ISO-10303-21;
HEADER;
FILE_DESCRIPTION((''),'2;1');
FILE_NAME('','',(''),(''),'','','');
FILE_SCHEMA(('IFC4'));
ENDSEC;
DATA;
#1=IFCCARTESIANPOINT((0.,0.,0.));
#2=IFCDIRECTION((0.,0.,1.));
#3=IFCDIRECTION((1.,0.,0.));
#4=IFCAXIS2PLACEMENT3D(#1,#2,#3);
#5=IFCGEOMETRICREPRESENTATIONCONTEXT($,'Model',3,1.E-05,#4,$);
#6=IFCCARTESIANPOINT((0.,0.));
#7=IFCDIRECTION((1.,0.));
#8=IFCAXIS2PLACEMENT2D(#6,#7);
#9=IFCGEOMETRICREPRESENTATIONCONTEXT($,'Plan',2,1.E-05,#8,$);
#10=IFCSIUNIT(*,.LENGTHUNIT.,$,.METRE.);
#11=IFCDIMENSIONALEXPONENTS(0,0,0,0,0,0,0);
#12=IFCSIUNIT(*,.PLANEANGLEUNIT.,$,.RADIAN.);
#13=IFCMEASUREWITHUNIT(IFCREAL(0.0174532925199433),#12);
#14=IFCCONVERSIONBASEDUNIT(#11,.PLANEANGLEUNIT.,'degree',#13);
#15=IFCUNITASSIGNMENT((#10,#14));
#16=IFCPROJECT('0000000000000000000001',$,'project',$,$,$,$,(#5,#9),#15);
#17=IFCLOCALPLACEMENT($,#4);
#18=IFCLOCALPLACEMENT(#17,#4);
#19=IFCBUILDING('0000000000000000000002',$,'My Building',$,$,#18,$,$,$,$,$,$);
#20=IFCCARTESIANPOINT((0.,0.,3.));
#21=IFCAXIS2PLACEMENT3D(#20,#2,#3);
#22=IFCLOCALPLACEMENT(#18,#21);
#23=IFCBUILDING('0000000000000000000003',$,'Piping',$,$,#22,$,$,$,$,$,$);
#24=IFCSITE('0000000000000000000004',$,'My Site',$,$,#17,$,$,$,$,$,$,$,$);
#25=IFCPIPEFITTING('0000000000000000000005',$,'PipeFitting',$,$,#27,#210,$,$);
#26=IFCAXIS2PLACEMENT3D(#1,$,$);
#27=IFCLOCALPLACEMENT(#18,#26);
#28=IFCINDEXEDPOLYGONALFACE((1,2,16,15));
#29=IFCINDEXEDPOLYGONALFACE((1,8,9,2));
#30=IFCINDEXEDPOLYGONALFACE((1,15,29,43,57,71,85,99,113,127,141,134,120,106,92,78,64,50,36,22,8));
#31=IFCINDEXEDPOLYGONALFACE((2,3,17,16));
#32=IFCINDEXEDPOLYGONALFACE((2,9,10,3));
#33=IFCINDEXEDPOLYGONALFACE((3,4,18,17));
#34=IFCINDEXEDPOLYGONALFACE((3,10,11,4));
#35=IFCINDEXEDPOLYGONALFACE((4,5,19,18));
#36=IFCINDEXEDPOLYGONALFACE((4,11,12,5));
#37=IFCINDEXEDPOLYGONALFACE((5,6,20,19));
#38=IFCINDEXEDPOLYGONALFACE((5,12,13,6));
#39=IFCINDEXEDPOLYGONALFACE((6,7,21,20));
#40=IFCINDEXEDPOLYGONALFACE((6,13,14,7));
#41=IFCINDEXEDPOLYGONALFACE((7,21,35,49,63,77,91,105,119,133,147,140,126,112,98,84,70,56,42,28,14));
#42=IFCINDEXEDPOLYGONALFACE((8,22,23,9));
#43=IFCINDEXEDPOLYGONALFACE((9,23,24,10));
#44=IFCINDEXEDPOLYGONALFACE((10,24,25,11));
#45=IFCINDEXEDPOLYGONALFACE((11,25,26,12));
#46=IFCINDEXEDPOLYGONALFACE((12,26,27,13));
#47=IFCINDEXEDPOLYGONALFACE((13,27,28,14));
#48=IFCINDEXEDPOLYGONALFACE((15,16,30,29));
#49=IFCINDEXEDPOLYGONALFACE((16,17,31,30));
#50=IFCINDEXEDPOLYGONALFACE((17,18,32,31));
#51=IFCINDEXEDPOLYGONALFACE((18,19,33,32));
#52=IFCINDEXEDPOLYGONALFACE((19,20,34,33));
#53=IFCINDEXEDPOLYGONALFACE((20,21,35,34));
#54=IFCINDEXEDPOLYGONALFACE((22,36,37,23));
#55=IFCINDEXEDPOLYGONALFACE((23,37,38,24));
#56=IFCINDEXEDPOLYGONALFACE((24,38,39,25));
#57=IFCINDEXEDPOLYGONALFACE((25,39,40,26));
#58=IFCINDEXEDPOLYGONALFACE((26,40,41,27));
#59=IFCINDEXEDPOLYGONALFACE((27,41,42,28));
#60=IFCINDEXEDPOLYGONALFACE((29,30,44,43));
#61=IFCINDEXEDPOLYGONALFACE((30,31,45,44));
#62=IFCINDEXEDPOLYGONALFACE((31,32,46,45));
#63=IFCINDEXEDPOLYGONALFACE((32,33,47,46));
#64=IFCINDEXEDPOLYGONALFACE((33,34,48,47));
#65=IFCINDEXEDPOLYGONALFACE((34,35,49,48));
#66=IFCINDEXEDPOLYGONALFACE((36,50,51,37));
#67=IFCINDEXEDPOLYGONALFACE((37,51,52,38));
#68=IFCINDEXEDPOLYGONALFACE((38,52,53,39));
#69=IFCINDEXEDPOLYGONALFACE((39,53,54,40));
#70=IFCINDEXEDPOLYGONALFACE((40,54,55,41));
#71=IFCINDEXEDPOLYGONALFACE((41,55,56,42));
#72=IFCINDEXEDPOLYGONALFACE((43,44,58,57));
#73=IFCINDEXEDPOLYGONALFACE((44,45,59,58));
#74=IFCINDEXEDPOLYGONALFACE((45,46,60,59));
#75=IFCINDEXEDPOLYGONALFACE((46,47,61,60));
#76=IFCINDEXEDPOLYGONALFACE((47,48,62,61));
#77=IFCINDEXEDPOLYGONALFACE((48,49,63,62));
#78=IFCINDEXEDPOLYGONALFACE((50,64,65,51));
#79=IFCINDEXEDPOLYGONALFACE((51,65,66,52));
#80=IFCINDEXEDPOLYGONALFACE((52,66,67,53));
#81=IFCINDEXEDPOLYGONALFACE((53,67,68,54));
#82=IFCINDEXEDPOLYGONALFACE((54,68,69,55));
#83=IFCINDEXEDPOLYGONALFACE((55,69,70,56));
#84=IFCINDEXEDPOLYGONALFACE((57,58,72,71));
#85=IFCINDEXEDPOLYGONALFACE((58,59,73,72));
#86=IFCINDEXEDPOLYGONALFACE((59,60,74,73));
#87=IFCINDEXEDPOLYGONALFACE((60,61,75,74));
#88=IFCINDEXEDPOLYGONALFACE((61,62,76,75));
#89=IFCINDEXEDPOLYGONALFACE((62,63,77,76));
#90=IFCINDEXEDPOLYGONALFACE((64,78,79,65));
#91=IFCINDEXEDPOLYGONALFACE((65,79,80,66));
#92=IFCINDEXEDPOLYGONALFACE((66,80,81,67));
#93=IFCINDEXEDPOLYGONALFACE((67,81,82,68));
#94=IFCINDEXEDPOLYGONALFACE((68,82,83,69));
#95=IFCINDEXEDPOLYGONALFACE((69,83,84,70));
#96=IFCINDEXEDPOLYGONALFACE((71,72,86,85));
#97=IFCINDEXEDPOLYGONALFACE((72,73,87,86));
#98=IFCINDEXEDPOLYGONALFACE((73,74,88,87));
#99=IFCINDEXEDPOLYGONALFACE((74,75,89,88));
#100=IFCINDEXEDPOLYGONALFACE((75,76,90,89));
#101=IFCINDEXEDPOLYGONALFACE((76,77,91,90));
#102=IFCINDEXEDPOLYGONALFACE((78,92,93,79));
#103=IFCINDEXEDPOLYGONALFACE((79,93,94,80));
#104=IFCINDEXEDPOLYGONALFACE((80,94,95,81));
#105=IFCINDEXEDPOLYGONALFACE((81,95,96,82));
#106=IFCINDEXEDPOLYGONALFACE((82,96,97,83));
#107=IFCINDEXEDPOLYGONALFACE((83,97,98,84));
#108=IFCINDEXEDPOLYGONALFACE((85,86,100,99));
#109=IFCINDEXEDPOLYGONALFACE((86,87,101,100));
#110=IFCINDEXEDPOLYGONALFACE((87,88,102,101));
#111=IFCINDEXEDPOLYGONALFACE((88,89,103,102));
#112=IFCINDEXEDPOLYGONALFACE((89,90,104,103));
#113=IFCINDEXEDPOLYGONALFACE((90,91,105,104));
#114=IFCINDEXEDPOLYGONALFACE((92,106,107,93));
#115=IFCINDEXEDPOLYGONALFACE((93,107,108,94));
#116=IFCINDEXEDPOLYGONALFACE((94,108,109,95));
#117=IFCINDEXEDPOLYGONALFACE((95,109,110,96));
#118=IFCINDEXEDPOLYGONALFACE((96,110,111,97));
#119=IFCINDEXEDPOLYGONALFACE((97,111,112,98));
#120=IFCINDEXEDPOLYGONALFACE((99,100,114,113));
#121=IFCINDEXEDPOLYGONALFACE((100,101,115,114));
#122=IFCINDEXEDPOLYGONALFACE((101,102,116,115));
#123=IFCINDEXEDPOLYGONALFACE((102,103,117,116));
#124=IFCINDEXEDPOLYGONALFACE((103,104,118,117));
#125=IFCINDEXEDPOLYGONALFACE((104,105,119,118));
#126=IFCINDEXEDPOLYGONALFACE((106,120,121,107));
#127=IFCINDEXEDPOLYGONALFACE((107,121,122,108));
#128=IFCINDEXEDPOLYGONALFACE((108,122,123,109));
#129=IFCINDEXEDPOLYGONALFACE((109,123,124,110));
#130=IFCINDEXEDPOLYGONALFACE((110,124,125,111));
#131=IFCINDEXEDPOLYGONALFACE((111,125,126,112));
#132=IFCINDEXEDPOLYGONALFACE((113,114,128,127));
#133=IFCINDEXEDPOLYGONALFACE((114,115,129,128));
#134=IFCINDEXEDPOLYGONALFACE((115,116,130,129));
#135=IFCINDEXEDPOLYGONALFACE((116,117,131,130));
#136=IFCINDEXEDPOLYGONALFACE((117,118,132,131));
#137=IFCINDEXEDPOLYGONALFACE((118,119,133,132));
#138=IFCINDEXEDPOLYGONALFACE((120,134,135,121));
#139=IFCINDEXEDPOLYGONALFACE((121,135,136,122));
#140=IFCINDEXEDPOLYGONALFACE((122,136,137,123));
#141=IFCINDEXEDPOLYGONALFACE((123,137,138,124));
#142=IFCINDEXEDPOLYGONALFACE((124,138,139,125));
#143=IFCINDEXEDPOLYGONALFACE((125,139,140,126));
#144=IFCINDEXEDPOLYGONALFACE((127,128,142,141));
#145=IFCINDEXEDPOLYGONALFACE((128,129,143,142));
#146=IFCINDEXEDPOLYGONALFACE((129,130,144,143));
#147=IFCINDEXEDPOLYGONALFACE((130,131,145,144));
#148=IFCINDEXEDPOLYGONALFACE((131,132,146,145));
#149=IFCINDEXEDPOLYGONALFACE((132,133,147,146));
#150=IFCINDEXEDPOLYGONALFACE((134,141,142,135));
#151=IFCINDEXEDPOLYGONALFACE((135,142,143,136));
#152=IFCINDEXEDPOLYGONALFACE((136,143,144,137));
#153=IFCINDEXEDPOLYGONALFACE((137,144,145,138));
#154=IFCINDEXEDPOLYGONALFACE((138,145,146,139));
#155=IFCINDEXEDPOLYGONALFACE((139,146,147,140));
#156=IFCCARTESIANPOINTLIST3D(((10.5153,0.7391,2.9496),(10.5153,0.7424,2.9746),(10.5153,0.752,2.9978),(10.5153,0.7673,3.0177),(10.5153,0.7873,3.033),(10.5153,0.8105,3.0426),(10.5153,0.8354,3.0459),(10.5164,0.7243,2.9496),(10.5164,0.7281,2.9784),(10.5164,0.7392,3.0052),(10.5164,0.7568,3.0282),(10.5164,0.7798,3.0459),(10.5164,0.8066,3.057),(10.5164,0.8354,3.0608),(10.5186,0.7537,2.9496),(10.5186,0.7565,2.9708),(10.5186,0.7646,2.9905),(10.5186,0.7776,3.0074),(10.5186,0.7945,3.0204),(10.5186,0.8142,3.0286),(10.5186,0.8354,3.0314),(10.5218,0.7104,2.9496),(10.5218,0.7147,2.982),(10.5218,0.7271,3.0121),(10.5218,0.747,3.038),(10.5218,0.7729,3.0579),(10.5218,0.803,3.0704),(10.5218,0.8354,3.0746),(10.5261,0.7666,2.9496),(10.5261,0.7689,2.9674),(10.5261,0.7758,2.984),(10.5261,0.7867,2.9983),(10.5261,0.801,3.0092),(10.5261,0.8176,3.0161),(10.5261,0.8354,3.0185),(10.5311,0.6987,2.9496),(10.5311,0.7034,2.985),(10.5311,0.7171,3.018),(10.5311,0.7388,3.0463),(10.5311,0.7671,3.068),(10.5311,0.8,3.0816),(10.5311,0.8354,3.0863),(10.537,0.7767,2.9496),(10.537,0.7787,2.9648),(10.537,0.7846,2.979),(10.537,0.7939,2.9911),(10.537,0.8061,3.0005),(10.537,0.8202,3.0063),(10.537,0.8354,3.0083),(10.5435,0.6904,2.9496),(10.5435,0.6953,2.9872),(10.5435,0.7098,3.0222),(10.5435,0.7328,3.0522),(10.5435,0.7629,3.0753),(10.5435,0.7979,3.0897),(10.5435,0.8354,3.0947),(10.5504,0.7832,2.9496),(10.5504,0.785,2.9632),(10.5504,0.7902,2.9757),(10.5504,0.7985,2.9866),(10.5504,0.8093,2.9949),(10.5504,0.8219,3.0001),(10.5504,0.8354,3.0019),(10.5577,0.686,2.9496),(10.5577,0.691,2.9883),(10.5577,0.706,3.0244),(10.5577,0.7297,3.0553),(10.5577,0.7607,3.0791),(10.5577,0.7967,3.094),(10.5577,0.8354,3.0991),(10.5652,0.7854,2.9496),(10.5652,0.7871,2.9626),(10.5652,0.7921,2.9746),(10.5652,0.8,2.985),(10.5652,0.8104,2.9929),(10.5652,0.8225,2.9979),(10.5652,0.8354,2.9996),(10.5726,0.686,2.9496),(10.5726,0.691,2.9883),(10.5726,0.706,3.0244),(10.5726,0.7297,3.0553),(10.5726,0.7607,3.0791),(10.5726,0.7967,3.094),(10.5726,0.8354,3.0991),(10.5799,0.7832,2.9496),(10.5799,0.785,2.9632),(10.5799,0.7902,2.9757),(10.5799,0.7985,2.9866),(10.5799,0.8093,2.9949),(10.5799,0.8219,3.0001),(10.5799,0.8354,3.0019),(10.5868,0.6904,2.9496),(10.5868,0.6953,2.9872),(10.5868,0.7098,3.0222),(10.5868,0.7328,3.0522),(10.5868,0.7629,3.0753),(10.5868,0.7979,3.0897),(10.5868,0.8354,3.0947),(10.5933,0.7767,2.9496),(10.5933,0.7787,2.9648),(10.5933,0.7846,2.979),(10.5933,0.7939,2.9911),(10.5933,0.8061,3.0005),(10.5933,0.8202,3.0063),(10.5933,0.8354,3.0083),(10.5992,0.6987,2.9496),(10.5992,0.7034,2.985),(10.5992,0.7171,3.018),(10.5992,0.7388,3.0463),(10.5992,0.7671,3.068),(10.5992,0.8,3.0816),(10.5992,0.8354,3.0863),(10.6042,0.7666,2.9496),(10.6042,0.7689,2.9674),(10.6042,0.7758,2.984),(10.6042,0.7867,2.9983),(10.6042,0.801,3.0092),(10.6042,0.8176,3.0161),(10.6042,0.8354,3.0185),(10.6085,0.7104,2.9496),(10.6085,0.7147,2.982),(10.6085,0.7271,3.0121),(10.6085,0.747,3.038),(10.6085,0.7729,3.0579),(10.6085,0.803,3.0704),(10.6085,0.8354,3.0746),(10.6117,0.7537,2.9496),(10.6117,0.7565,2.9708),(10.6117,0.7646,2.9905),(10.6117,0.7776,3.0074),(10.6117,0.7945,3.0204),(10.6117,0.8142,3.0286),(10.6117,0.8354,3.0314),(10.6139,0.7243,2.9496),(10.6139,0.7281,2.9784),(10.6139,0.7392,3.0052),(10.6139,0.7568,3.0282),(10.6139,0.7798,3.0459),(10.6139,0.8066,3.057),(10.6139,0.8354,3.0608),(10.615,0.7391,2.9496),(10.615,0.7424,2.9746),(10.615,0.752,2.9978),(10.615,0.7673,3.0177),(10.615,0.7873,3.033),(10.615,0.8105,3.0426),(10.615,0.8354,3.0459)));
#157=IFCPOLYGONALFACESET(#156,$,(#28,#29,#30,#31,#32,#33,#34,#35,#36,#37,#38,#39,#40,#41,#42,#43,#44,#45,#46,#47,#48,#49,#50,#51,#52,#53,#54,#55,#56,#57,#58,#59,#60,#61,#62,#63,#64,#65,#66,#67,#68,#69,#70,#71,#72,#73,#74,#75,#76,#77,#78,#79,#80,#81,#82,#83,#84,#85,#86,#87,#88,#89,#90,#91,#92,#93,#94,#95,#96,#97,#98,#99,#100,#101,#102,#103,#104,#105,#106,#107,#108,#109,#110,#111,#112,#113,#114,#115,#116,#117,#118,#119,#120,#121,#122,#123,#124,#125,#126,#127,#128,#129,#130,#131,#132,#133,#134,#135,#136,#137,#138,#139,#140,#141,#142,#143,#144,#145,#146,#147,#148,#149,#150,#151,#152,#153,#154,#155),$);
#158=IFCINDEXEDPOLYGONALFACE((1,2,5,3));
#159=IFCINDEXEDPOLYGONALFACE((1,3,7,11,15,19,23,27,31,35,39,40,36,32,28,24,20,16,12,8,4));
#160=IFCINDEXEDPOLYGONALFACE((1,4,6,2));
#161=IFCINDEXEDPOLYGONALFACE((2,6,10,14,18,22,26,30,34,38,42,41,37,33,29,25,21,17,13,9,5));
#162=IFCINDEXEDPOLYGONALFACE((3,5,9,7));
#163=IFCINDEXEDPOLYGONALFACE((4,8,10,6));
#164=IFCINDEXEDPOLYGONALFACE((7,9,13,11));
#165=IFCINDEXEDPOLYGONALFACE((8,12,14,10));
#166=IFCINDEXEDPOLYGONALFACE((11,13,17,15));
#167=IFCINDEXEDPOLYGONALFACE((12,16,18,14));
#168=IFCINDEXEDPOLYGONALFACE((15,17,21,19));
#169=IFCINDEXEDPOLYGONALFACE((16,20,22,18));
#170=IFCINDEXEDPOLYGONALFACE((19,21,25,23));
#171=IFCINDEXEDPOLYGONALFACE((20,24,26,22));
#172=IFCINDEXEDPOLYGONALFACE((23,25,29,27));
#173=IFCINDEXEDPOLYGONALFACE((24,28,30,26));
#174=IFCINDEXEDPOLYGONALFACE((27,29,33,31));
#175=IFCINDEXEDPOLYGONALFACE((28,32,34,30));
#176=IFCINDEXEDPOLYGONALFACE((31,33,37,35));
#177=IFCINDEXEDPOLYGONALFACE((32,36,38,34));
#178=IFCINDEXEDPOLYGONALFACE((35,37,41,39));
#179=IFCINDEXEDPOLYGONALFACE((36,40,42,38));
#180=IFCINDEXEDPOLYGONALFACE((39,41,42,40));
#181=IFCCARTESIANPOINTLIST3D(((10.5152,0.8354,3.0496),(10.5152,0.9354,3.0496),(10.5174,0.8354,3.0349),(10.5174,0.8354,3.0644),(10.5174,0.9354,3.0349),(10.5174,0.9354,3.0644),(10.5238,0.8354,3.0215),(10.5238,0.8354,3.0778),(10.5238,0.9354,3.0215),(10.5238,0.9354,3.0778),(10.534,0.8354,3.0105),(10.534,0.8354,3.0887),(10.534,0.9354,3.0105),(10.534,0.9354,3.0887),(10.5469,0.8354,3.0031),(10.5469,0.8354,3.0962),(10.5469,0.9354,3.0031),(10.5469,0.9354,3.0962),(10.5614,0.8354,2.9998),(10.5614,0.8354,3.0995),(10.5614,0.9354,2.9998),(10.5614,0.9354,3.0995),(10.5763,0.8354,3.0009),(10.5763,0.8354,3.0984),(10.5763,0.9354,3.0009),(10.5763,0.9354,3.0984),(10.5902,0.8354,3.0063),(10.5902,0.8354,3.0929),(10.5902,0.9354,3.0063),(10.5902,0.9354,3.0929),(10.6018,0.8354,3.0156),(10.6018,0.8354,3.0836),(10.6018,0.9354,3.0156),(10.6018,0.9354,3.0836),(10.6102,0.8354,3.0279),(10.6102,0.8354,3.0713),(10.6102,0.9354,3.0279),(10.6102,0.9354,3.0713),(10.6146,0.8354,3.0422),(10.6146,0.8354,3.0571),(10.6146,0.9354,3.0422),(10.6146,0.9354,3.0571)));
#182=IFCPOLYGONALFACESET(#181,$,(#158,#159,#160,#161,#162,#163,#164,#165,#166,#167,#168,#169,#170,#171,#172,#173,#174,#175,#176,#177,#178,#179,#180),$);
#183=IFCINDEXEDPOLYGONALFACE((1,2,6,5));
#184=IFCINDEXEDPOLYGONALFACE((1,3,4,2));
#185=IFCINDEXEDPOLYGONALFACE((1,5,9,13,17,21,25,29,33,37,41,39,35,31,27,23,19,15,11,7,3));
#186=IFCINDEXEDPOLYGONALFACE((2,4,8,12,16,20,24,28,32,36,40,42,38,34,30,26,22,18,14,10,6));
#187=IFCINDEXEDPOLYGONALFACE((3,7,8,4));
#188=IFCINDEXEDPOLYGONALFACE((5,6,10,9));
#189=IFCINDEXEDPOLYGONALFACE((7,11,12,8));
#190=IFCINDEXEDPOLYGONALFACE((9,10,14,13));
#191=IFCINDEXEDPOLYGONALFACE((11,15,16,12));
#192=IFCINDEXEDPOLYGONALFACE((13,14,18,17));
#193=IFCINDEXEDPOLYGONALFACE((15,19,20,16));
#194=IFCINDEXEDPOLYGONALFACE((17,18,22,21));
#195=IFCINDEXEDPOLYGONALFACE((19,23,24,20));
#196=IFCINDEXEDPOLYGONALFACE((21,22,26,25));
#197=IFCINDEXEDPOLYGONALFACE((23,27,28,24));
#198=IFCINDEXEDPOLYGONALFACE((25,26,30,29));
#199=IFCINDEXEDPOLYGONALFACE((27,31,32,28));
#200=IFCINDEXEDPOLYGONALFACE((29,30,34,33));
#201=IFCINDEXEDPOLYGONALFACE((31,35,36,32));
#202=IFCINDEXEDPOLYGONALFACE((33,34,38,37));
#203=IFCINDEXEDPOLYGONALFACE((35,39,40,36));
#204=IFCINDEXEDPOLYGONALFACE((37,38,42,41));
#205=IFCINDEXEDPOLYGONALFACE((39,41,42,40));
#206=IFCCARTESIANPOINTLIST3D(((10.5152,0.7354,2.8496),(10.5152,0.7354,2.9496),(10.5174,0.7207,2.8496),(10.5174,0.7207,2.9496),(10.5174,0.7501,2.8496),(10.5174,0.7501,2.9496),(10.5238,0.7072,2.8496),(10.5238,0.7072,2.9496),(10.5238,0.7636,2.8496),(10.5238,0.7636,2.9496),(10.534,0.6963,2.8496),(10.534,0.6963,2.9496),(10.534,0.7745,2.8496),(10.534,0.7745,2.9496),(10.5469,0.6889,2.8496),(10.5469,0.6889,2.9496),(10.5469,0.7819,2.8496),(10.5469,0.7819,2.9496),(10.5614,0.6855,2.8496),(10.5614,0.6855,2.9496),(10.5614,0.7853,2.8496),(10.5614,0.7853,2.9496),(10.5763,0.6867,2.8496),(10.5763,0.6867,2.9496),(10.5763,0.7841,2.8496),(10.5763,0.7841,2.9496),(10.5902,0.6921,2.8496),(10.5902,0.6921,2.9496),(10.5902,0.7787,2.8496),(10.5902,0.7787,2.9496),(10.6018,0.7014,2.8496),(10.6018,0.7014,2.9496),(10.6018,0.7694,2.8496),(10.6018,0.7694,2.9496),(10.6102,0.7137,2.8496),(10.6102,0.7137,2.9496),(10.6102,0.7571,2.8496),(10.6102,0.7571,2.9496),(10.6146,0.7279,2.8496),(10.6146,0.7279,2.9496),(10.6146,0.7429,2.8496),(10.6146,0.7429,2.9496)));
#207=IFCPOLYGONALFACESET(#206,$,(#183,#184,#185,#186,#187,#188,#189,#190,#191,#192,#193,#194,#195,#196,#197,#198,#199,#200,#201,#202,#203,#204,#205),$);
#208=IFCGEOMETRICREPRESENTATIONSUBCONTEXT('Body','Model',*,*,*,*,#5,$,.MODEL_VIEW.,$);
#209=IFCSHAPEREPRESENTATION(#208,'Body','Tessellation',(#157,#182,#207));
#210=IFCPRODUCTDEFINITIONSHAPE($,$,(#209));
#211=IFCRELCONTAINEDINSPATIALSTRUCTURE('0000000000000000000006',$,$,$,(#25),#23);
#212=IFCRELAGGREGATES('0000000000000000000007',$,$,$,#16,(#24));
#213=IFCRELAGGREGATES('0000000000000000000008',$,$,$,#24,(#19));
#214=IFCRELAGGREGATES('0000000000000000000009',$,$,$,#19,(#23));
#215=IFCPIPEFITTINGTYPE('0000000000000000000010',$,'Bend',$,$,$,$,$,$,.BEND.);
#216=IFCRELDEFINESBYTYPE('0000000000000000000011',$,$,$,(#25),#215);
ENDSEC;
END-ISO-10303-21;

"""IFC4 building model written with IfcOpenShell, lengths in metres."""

from ifc_helpers import new_model, entity, si_unit, converted_unit, frame, origin_with_axes, origin_2d_with_axis, place, context, subcontext, project, spatial, circle, extrude, source, transform, mapped, type_object, type_shapes, element, save


model = new_model("IFC4")

# Units and contexts
model_context = context("Model", 3, precision=1e-05, world=origin_with_axes())
plan_context = context("Plan", 2, precision=1e-05, world=origin_2d_with_axis())
body_context = subcontext(model_context, "Body", "Model", "MODEL_VIEW")
ifc_project = project(units=[si_unit("LENGTHUNIT", "METRE"), converted_unit("PLANEANGLEUNIT", "degree", entity("IfcReal", 0.0174532925199433), si_unit("PLANEANGLEUNIT", "RADIAN"), dimensions=[0, 0, 0, 0, 0, 0, 0])], contexts=[model_context, plan_context])

# Site, buildings
site_placement = place(None, origin_with_axes())
site = spatial("IfcSite", under=ifc_project, at=site_placement, Name="My Site")
building_1_placement = place(site_placement, origin_with_axes())
building_1 = spatial("IfcBuilding", under=site, at=building_1_placement, Name="My Building")
building_2_placement = place(building_1_placement, frame((0.0, 0.0, 3.0), z_axis=(0.0, 0.0, 1.0), x_axis=(1.0, 0.0, 0.0)))
building_2 = spatial("IfcBuilding", under=building_1, at=building_2_placement, Name="Piping")

# Pipe fitting
pipe_fitting_type_1 = type_object("IfcPipeFittingType", Name="Bend", PredefinedType="BEND")
shared_shape = source(origin_with_axes(), body_context, "Body", "SolidModel", [
    entity("IfcSweptDiskSolid", entity("IfcIndexedPolyCurve", entity("IfcCartesianPointList3D", [[0.0, 0.0, 0.1], [0.0, 0.0293, 0.1707], [0.0, 0.1, 0.2]]), [entity("IfcArcIndex", [1, 2, 3])]), 0.05),
    extrude(circle(Radius=0.05), origin_with_axes(), (0.0, 0.0, 1.0), 0.1),
    extrude(circle(Radius=0.05), frame((0.0, 0.1, 0.2), z_axis=(0.0, 1.0, 0.0), x_axis=(1.0, 0.0, 0.0)), (0.0, 0.0, 1.0), 0.1),
])
type_shapes(pipe_fitting_type_1, [shared_shape])
for number, where, z_axis, x_axis, name in (
    (1, (10.5652, 0.9354, 0.0496), (0.0, -1.0, 0.0), (-1.0, 0.0, 0.0), "PipeFitting"),
):
    element("IfcPipeFitting", number, at=place(building_2_placement, frame(where, z_axis=z_axis, x_axis=x_axis)), inside=building_2, type_object=pipe_fitting_type_1, Name=name, context=body_context, shape_type="MappedRepresentation", body=[
        mapped(shared_shape, transform((0.0, 0.0, 0.0), x_axis=(1.0, 0.0, 0.0), y_axis=(0.0, 1.0, 0.0), z_axis=(0.0, 0.0, 1.0), scale=1.0)),
    ])

save(model, "model.ifc")
